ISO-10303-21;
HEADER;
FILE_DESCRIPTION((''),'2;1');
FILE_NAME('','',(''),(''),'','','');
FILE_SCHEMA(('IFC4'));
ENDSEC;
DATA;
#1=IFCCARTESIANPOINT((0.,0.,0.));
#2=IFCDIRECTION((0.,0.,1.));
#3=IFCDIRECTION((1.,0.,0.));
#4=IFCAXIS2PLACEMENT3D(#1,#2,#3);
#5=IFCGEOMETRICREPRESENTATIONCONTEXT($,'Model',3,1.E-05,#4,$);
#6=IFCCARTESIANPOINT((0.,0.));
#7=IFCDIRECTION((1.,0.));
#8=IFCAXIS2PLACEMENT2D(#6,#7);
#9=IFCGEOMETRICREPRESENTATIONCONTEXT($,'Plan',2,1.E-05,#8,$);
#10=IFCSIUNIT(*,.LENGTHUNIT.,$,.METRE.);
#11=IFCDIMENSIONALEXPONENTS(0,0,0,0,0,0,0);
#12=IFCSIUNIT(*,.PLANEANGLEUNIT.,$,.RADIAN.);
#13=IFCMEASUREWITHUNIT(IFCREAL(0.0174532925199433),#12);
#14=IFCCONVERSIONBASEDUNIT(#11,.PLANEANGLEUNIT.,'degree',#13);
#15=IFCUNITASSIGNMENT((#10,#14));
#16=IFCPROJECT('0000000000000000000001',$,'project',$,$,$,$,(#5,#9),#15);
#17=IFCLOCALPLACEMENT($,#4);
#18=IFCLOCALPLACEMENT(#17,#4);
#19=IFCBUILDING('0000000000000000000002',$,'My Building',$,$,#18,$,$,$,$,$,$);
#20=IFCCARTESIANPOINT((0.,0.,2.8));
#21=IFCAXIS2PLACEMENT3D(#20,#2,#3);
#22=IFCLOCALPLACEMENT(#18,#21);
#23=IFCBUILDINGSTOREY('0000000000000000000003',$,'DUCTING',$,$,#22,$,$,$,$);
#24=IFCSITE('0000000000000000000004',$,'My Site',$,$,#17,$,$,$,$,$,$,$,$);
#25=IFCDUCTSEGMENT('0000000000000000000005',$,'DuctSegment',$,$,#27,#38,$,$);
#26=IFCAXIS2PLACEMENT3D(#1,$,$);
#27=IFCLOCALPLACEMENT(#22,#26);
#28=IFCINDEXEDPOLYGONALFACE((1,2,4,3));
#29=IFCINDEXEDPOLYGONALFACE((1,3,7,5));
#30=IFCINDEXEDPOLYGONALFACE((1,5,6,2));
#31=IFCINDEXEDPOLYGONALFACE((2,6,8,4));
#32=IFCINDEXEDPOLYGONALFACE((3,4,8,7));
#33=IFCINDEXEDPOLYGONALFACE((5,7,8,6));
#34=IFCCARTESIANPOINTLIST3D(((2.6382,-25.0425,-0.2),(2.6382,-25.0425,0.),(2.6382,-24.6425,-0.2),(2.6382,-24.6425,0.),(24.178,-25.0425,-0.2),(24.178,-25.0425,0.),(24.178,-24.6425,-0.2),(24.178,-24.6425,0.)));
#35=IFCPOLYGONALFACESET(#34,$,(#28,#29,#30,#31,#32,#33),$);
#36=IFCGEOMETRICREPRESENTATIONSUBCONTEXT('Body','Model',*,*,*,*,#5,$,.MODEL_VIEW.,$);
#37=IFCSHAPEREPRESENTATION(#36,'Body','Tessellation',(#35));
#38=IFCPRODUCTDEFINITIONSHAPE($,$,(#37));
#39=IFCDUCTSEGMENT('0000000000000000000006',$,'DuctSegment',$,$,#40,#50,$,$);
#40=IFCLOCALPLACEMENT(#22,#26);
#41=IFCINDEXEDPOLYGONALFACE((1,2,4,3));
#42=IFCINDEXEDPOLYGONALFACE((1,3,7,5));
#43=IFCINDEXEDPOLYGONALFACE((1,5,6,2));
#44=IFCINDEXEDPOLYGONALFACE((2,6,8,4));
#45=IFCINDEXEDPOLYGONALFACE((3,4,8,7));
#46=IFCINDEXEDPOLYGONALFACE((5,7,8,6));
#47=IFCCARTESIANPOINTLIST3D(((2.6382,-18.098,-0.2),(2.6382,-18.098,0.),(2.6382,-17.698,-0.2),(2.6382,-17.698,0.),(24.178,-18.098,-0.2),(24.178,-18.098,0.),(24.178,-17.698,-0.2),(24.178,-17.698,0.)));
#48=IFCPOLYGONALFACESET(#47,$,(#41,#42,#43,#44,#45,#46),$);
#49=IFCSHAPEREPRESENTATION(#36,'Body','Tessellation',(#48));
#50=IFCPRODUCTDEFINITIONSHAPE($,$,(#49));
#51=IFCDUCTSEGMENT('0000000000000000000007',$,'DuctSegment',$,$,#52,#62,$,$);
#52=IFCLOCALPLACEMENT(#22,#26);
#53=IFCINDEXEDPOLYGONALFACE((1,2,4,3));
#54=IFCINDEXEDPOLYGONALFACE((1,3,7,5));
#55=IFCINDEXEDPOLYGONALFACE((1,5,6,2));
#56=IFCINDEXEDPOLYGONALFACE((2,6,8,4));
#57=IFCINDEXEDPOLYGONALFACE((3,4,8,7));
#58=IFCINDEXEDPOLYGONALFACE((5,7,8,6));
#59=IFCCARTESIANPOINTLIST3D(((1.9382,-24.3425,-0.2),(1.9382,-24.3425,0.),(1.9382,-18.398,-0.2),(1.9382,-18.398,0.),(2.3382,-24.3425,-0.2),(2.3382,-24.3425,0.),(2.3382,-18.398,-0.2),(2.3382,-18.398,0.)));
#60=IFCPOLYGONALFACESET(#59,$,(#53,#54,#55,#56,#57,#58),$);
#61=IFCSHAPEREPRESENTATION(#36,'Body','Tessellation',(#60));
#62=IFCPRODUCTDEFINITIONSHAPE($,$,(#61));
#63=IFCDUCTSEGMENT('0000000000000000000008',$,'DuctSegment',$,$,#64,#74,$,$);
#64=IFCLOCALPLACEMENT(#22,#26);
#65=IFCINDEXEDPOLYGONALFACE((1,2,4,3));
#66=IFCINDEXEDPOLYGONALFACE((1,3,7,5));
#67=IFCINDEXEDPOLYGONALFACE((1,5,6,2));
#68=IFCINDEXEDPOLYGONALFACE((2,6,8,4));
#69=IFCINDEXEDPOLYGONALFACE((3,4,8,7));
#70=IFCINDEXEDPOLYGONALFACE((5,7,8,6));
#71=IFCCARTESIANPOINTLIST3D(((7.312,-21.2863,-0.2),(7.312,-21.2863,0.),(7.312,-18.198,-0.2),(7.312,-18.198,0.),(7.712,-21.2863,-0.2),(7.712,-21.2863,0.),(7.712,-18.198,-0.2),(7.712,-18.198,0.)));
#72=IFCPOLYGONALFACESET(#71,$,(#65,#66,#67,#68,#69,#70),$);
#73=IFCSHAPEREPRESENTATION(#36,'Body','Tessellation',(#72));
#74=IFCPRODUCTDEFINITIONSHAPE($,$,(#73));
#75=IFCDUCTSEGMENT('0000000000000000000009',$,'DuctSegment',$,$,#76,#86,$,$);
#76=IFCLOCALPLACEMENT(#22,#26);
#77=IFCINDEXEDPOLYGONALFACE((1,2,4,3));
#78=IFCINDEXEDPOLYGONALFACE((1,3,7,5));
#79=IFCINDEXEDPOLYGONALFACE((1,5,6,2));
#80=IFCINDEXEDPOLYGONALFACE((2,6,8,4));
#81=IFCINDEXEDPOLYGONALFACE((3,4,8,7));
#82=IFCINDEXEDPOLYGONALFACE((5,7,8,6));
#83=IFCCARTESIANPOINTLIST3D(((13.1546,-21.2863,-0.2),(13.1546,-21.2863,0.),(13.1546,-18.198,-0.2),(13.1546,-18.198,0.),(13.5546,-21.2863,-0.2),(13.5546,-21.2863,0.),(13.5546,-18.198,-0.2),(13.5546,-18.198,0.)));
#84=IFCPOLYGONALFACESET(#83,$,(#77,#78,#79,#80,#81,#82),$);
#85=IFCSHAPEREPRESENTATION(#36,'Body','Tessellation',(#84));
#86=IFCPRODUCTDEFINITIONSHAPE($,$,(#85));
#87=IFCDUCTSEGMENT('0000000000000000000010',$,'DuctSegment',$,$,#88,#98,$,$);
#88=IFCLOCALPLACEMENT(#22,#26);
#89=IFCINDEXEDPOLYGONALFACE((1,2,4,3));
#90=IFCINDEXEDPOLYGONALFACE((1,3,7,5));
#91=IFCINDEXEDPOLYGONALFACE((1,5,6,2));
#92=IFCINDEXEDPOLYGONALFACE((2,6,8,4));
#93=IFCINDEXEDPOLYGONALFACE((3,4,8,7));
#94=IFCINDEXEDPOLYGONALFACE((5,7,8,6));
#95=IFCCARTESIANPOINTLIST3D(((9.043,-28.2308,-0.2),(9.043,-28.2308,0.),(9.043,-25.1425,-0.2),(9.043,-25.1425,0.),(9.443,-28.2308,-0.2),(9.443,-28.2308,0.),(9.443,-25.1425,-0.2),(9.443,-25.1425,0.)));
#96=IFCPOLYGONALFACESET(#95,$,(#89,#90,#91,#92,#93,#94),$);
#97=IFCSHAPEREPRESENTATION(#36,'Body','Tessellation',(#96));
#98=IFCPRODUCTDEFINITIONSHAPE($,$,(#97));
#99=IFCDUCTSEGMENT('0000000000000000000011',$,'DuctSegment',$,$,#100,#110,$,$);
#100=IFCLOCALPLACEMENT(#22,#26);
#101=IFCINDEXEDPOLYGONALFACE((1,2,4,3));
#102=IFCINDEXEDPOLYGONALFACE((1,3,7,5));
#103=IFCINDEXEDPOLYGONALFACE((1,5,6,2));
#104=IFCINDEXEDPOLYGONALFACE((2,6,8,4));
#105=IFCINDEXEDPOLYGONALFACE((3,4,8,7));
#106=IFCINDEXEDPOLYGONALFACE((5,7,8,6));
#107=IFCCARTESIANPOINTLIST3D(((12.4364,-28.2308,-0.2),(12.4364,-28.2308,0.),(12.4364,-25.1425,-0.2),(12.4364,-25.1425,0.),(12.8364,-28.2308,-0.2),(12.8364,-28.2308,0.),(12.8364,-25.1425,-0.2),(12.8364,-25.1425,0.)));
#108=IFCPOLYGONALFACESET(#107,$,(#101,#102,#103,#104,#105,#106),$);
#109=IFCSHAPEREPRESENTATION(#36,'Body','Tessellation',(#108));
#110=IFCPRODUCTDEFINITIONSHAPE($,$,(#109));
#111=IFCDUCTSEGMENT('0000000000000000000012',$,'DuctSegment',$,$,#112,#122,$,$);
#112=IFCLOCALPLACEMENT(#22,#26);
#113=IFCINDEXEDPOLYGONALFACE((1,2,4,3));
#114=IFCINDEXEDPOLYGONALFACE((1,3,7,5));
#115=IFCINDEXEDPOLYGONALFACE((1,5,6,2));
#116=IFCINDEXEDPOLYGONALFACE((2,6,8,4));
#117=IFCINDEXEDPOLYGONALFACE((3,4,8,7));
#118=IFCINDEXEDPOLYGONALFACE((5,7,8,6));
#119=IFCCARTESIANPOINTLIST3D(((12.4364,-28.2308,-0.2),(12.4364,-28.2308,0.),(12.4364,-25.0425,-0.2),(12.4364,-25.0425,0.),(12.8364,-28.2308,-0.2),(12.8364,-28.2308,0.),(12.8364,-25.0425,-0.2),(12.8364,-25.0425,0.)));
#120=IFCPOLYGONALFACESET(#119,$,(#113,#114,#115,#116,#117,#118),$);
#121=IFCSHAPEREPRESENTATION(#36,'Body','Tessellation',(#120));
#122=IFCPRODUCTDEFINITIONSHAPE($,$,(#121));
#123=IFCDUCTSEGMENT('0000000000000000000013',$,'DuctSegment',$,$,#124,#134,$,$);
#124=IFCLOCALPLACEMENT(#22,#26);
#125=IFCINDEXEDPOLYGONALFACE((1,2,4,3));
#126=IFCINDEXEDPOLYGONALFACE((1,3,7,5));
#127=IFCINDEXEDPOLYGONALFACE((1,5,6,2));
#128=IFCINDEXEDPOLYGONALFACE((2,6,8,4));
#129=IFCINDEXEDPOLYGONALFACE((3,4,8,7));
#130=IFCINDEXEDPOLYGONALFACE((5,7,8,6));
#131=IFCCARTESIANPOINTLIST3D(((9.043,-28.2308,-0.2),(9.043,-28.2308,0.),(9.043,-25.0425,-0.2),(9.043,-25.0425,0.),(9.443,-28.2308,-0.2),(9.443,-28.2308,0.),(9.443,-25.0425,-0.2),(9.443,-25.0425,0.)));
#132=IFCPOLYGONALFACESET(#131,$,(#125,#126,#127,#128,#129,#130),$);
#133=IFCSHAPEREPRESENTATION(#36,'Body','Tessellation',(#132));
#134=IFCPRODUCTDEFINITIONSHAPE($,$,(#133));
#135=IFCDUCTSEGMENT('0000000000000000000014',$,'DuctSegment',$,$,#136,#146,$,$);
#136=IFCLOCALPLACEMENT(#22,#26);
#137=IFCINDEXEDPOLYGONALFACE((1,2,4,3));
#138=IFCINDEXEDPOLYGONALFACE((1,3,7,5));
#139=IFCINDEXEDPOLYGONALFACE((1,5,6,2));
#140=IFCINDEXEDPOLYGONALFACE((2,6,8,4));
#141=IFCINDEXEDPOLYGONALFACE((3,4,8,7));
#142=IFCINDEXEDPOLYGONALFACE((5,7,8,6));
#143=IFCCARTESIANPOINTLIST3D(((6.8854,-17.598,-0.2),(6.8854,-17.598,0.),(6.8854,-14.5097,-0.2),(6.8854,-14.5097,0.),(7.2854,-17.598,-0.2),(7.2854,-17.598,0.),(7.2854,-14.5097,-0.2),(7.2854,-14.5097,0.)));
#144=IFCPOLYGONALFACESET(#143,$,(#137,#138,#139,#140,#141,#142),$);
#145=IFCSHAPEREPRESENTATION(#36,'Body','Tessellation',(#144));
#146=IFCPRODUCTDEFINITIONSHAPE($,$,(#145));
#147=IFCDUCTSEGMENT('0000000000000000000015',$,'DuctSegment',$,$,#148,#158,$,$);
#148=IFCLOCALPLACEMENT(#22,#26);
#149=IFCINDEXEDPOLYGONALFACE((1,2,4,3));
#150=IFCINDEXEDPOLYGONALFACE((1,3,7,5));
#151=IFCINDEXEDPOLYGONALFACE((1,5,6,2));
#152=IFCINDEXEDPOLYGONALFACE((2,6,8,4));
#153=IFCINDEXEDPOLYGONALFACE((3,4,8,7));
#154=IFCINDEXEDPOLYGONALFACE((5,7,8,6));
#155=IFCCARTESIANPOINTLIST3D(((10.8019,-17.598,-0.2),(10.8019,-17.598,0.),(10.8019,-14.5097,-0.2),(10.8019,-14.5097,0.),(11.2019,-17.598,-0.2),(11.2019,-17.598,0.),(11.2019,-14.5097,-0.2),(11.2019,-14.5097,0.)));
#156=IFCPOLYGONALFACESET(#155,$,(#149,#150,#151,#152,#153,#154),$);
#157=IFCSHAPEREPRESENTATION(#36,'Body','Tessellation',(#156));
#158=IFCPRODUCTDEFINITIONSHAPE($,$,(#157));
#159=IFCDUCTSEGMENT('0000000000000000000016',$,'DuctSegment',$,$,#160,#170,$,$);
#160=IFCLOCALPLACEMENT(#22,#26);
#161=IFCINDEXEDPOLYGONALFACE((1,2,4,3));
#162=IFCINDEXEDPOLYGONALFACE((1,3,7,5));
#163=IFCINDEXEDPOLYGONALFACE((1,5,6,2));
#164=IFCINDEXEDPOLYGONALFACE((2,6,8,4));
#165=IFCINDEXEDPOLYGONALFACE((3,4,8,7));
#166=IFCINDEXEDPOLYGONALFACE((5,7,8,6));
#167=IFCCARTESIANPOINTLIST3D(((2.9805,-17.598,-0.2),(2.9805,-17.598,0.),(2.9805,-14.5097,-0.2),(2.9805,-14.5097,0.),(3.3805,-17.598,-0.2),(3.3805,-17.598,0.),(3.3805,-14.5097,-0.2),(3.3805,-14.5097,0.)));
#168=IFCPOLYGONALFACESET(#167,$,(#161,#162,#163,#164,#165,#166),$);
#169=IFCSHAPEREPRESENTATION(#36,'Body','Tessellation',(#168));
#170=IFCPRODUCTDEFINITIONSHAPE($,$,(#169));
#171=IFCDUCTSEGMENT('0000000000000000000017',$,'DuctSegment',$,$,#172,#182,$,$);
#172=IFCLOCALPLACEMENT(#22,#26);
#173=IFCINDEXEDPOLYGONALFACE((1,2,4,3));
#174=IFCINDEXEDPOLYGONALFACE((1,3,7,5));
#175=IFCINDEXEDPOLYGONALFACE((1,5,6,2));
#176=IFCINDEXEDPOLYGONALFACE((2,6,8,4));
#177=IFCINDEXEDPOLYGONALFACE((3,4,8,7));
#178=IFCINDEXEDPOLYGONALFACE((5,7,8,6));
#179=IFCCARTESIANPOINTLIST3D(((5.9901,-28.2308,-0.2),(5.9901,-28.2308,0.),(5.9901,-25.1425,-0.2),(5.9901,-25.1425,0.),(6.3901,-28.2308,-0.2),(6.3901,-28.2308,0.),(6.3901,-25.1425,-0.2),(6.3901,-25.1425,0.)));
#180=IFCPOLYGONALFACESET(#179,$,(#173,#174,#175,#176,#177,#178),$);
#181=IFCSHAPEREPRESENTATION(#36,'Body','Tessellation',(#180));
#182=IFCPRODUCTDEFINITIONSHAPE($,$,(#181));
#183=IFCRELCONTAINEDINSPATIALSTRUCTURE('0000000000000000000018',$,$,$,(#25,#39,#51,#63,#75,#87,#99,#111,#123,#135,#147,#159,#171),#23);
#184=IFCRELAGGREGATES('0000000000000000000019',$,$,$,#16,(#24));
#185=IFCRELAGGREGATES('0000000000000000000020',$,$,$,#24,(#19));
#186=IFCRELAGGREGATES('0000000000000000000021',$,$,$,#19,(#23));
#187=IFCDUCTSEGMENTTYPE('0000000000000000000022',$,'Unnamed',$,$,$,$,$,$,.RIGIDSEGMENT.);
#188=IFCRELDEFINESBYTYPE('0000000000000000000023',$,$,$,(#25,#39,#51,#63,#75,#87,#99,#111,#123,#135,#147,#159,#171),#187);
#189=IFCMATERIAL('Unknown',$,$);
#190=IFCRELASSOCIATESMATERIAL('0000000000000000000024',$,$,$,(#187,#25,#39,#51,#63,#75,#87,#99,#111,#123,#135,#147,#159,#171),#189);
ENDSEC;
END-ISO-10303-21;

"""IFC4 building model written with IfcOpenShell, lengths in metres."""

from ifc_helpers import new_model, entity, si_unit, converted_unit, frame, origin_with_axes, origin_2d_with_axis, place, context, subcontext, project, spatial, rectangle, extrude, material, material_profile, profile_set, profile_usage, type_object, element, save


model = new_model("IFC4")

# Units and contexts
model_context = context("Model", 3, precision=1e-05, world=origin_with_axes())
plan_context = context("Plan", 2, precision=1e-05, world=origin_2d_with_axis())
body_context = subcontext(model_context, "Body", "Model", "MODEL_VIEW")
ifc_project = project(units=[si_unit("LENGTHUNIT", "METRE"), converted_unit("PLANEANGLEUNIT", "degree", entity("IfcReal", 0.0174532925199433), si_unit("PLANEANGLEUNIT", "RADIAN"), dimensions=[0, 0, 0, 0, 0, 0, 0])], contexts=[model_context, plan_context])

# Site, building, storey
site_placement = place(None, origin_with_axes())
site = spatial("IfcSite", under=ifc_project, at=site_placement, Name="My Site")
building_placement = place(site_placement, origin_with_axes())
building = spatial("IfcBuilding", under=site, at=building_placement, Name="My Building")
storey_placement = place(building_placement, frame((0.0, 0.0, 2.8), z_axis=(0.0, 0.0, 1.0), x_axis=(1.0, 0.0, 0.0)))
storey = spatial("IfcBuildingStorey", under=building, at=storey_placement, Name="DUCTING")

# Duct segments
ifc_material = material(Name="Unknown")
ifc_material_profile_1 = material_profile(ifc_material, rectangle(XDim=0.4, YDim=0.2))
ifc_profile_set_1 = profile_set([ifc_material_profile_1])
ifc_profile_usage_1 = profile_usage(ifc_profile_set_1, cardinal=5)
duct_segment_type = type_object("IfcDuctSegmentType", Name="Unnamed", PredefinedType="RIGIDSEGMENT", material=ifc_profile_set_1)
duct_segment_1_placement = place(storey_placement, frame((2.6382, -24.8425, -0.1), z_axis=(1.0, 0.0, 0.0), x_axis=(0.0, 1.0, 0.0)))
element("IfcDuctSegment", 1, at=duct_segment_1_placement, inside=storey, type_object=duct_segment_type, material=ifc_profile_usage_1, Name="DuctSegment", context=body_context, shape_type="SweptSolid", body=[
    extrude(rectangle(XDim=0.4, YDim=0.2), origin_with_axes(), (0.0, 0.0, 1.0), 21.5398),
])
ifc_profile_usage_2 = profile_usage(ifc_profile_set_1, cardinal=5)
duct_segment_2_placement = place(storey_placement, frame((2.6382, -17.898, -0.1), z_axis=(1.0, 0.0, 0.0), x_axis=(0.0, 1.0, 0.0)))
element("IfcDuctSegment", 2, at=duct_segment_2_placement, inside=storey, type_object=duct_segment_type, material=ifc_profile_usage_2, Name="DuctSegment", context=body_context, shape_type="SweptSolid", body=[
    extrude(rectangle(XDim=0.4, YDim=0.2), origin_with_axes(), (0.0, 0.0, 1.0), 21.5398),
])
ifc_profile_usage_3 = profile_usage(ifc_profile_set_1, cardinal=5)
duct_segment_3_placement = place(storey_placement, frame((2.1382, -18.398, -0.1), z_axis=(0.0, -1.0, 0.0), x_axis=(1.0, 0.0, 0.0)))
element("IfcDuctSegment", 3, at=duct_segment_3_placement, inside=storey, type_object=duct_segment_type, material=ifc_profile_usage_3, Name="DuctSegment", context=body_context, shape_type="SweptSolid", body=[
    extrude(rectangle(XDim=0.4, YDim=0.2), origin_with_axes(), (0.0, 0.0, 1.0), 5.9445),
])
ifc_profile_usage_4 = profile_usage(ifc_profile_set_1, cardinal=5)
duct_segment_4_placement = place(storey_placement, frame((7.512, -18.198, -0.1), z_axis=(0.0, -1.0, 0.0), x_axis=(1.0, 0.0, 0.0)))
element("IfcDuctSegment", 4, at=duct_segment_4_placement, inside=storey, type_object=duct_segment_type, material=ifc_profile_usage_4, Name="DuctSegment", context=body_context, shape_type="SweptSolid", body=[
    extrude(rectangle(XDim=0.4, YDim=0.2), origin_with_axes(), (0.0, 0.0, 1.0), 3.0883),
])
ifc_profile_usage_5 = profile_usage(ifc_profile_set_1, cardinal=5)
duct_segment_5_placement = place(storey_placement, frame((13.3546, -18.198, -0.1), z_axis=(0.0, -1.0, 0.0), x_axis=(1.0, 0.0, 0.0)))
element("IfcDuctSegment", 5, at=duct_segment_5_placement, inside=storey, type_object=duct_segment_type, material=ifc_profile_usage_5, Name="DuctSegment", context=body_context, shape_type="SweptSolid", body=[
    extrude(rectangle(XDim=0.4, YDim=0.2), origin_with_axes(), (0.0, 0.0, 1.0), 3.0883),
])
ifc_profile_usage_6 = profile_usage(ifc_profile_set_1, cardinal=5)
duct_segment_6_placement = place(storey_placement, frame((9.243, -25.1425, -0.1), z_axis=(0.0, -1.0, 0.0), x_axis=(1.0, 0.0, 0.0)))
element("IfcDuctSegment", 6, at=duct_segment_6_placement, inside=storey, type_object=duct_segment_type, material=ifc_profile_usage_6, Name="DuctSegment", context=body_context, shape_type="SweptSolid", body=[
    extrude(rectangle(XDim=0.4, YDim=0.2), origin_with_axes(), (0.0, 0.0, 1.0), 3.0883),
])
ifc_profile_usage_7 = profile_usage(ifc_profile_set_1, cardinal=5)
duct_segment_7_placement = place(storey_placement, frame((12.6364, -25.1425, -0.1), z_axis=(0.0, -1.0, 0.0), x_axis=(1.0, 0.0, 0.0)))
element("IfcDuctSegment", 7, at=duct_segment_7_placement, inside=storey, type_object=duct_segment_type, material=ifc_profile_usage_7, Name="DuctSegment", context=body_context, shape_type="SweptSolid", body=[
    extrude(rectangle(XDim=0.4, YDim=0.2), origin_with_axes(), (0.0, 0.0, 1.0), 3.0883),
])
ifc_profile_usage_8 = profile_usage(ifc_profile_set_1, cardinal=5)
duct_segment_8_placement = place(storey_placement, frame((12.6364, -25.0425, -0.1), z_axis=(0.0, -1.0, 0.0), x_axis=(1.0, 0.0, 0.0)))
element("IfcDuctSegment", 8, at=duct_segment_8_placement, inside=storey, type_object=duct_segment_type, material=ifc_profile_usage_8, Name="DuctSegment", context=body_context, shape_type="SweptSolid", body=[
    extrude(rectangle(XDim=0.4, YDim=0.2), origin_with_axes(), (0.0, 0.0, 1.0), 3.1883),
])
ifc_profile_usage_9 = profile_usage(ifc_profile_set_1, cardinal=5)
duct_segment_9_placement = place(storey_placement, frame((9.243, -25.0425, -0.1), z_axis=(0.0, -1.0, 0.0), x_axis=(1.0, 0.0, 0.0)))
element("IfcDuctSegment", 9, at=duct_segment_9_placement, inside=storey, type_object=duct_segment_type, material=ifc_profile_usage_9, Name="DuctSegment", context=body_context, shape_type="SweptSolid", body=[
    extrude(rectangle(XDim=0.4, YDim=0.2), origin_with_axes(), (0.0, 0.0, 1.0), 3.1883),
])
ifc_profile_usage_10 = profile_usage(ifc_profile_set_1, cardinal=5)
duct_segment_10_placement = place(storey_placement, frame((7.0854, -17.598, -0.1), z_axis=(0.0, 1.0, 0.0), x_axis=(-1.0, 0.0, 0.0)))
element("IfcDuctSegment", 10, at=duct_segment_10_placement, inside=storey, type_object=duct_segment_type, material=ifc_profile_usage_10, Name="DuctSegment", context=body_context, shape_type="SweptSolid", body=[
    extrude(rectangle(XDim=0.4, YDim=0.2), origin_with_axes(), (0.0, 0.0, 1.0), 3.0883),
])
ifc_profile_usage_11 = profile_usage(ifc_profile_set_1, cardinal=5)
duct_segment_11_placement = place(storey_placement, frame((11.0019, -17.598, -0.1), z_axis=(0.0, 1.0, 0.0), x_axis=(-1.0, 0.0, 0.0)))
element("IfcDuctSegment", 11, at=duct_segment_11_placement, inside=storey, type_object=duct_segment_type, material=ifc_profile_usage_11, Name="DuctSegment", context=body_context, shape_type="SweptSolid", body=[
    extrude(rectangle(XDim=0.4, YDim=0.2), origin_with_axes(), (0.0, 0.0, 1.0), 3.0883),
])
ifc_profile_usage_12 = profile_usage(ifc_profile_set_1, cardinal=5)
duct_segment_12_placement = place(storey_placement, frame((3.1805, -17.598, -0.1), z_axis=(0.0, 1.0, 0.0), x_axis=(-1.0, 0.0, 0.0)))
element("IfcDuctSegment", 12, at=duct_segment_12_placement, inside=storey, type_object=duct_segment_type, material=ifc_profile_usage_12, Name="DuctSegment", context=body_context, shape_type="SweptSolid", body=[
    extrude(rectangle(XDim=0.4, YDim=0.2), origin_with_axes(), (0.0, 0.0, 1.0), 3.0883),
])
ifc_profile_usage_13 = profile_usage(ifc_profile_set_1, cardinal=5)
duct_segment_13_placement = place(storey_placement, frame((6.1901, -28.2308, -0.1), z_axis=(0.0, 1.0, 0.0), x_axis=(-1.0, 0.0, 0.0)))
element("IfcDuctSegment", 13, at=duct_segment_13_placement, inside=storey, type_object=duct_segment_type, material=ifc_profile_usage_13, Name="DuctSegment", context=body_context, shape_type="SweptSolid", body=[
    extrude(rectangle(XDim=0.4, YDim=0.2), origin_with_axes(), (0.0, 0.0, 1.0), 3.0883),
])

save(model, "model.ifc")
